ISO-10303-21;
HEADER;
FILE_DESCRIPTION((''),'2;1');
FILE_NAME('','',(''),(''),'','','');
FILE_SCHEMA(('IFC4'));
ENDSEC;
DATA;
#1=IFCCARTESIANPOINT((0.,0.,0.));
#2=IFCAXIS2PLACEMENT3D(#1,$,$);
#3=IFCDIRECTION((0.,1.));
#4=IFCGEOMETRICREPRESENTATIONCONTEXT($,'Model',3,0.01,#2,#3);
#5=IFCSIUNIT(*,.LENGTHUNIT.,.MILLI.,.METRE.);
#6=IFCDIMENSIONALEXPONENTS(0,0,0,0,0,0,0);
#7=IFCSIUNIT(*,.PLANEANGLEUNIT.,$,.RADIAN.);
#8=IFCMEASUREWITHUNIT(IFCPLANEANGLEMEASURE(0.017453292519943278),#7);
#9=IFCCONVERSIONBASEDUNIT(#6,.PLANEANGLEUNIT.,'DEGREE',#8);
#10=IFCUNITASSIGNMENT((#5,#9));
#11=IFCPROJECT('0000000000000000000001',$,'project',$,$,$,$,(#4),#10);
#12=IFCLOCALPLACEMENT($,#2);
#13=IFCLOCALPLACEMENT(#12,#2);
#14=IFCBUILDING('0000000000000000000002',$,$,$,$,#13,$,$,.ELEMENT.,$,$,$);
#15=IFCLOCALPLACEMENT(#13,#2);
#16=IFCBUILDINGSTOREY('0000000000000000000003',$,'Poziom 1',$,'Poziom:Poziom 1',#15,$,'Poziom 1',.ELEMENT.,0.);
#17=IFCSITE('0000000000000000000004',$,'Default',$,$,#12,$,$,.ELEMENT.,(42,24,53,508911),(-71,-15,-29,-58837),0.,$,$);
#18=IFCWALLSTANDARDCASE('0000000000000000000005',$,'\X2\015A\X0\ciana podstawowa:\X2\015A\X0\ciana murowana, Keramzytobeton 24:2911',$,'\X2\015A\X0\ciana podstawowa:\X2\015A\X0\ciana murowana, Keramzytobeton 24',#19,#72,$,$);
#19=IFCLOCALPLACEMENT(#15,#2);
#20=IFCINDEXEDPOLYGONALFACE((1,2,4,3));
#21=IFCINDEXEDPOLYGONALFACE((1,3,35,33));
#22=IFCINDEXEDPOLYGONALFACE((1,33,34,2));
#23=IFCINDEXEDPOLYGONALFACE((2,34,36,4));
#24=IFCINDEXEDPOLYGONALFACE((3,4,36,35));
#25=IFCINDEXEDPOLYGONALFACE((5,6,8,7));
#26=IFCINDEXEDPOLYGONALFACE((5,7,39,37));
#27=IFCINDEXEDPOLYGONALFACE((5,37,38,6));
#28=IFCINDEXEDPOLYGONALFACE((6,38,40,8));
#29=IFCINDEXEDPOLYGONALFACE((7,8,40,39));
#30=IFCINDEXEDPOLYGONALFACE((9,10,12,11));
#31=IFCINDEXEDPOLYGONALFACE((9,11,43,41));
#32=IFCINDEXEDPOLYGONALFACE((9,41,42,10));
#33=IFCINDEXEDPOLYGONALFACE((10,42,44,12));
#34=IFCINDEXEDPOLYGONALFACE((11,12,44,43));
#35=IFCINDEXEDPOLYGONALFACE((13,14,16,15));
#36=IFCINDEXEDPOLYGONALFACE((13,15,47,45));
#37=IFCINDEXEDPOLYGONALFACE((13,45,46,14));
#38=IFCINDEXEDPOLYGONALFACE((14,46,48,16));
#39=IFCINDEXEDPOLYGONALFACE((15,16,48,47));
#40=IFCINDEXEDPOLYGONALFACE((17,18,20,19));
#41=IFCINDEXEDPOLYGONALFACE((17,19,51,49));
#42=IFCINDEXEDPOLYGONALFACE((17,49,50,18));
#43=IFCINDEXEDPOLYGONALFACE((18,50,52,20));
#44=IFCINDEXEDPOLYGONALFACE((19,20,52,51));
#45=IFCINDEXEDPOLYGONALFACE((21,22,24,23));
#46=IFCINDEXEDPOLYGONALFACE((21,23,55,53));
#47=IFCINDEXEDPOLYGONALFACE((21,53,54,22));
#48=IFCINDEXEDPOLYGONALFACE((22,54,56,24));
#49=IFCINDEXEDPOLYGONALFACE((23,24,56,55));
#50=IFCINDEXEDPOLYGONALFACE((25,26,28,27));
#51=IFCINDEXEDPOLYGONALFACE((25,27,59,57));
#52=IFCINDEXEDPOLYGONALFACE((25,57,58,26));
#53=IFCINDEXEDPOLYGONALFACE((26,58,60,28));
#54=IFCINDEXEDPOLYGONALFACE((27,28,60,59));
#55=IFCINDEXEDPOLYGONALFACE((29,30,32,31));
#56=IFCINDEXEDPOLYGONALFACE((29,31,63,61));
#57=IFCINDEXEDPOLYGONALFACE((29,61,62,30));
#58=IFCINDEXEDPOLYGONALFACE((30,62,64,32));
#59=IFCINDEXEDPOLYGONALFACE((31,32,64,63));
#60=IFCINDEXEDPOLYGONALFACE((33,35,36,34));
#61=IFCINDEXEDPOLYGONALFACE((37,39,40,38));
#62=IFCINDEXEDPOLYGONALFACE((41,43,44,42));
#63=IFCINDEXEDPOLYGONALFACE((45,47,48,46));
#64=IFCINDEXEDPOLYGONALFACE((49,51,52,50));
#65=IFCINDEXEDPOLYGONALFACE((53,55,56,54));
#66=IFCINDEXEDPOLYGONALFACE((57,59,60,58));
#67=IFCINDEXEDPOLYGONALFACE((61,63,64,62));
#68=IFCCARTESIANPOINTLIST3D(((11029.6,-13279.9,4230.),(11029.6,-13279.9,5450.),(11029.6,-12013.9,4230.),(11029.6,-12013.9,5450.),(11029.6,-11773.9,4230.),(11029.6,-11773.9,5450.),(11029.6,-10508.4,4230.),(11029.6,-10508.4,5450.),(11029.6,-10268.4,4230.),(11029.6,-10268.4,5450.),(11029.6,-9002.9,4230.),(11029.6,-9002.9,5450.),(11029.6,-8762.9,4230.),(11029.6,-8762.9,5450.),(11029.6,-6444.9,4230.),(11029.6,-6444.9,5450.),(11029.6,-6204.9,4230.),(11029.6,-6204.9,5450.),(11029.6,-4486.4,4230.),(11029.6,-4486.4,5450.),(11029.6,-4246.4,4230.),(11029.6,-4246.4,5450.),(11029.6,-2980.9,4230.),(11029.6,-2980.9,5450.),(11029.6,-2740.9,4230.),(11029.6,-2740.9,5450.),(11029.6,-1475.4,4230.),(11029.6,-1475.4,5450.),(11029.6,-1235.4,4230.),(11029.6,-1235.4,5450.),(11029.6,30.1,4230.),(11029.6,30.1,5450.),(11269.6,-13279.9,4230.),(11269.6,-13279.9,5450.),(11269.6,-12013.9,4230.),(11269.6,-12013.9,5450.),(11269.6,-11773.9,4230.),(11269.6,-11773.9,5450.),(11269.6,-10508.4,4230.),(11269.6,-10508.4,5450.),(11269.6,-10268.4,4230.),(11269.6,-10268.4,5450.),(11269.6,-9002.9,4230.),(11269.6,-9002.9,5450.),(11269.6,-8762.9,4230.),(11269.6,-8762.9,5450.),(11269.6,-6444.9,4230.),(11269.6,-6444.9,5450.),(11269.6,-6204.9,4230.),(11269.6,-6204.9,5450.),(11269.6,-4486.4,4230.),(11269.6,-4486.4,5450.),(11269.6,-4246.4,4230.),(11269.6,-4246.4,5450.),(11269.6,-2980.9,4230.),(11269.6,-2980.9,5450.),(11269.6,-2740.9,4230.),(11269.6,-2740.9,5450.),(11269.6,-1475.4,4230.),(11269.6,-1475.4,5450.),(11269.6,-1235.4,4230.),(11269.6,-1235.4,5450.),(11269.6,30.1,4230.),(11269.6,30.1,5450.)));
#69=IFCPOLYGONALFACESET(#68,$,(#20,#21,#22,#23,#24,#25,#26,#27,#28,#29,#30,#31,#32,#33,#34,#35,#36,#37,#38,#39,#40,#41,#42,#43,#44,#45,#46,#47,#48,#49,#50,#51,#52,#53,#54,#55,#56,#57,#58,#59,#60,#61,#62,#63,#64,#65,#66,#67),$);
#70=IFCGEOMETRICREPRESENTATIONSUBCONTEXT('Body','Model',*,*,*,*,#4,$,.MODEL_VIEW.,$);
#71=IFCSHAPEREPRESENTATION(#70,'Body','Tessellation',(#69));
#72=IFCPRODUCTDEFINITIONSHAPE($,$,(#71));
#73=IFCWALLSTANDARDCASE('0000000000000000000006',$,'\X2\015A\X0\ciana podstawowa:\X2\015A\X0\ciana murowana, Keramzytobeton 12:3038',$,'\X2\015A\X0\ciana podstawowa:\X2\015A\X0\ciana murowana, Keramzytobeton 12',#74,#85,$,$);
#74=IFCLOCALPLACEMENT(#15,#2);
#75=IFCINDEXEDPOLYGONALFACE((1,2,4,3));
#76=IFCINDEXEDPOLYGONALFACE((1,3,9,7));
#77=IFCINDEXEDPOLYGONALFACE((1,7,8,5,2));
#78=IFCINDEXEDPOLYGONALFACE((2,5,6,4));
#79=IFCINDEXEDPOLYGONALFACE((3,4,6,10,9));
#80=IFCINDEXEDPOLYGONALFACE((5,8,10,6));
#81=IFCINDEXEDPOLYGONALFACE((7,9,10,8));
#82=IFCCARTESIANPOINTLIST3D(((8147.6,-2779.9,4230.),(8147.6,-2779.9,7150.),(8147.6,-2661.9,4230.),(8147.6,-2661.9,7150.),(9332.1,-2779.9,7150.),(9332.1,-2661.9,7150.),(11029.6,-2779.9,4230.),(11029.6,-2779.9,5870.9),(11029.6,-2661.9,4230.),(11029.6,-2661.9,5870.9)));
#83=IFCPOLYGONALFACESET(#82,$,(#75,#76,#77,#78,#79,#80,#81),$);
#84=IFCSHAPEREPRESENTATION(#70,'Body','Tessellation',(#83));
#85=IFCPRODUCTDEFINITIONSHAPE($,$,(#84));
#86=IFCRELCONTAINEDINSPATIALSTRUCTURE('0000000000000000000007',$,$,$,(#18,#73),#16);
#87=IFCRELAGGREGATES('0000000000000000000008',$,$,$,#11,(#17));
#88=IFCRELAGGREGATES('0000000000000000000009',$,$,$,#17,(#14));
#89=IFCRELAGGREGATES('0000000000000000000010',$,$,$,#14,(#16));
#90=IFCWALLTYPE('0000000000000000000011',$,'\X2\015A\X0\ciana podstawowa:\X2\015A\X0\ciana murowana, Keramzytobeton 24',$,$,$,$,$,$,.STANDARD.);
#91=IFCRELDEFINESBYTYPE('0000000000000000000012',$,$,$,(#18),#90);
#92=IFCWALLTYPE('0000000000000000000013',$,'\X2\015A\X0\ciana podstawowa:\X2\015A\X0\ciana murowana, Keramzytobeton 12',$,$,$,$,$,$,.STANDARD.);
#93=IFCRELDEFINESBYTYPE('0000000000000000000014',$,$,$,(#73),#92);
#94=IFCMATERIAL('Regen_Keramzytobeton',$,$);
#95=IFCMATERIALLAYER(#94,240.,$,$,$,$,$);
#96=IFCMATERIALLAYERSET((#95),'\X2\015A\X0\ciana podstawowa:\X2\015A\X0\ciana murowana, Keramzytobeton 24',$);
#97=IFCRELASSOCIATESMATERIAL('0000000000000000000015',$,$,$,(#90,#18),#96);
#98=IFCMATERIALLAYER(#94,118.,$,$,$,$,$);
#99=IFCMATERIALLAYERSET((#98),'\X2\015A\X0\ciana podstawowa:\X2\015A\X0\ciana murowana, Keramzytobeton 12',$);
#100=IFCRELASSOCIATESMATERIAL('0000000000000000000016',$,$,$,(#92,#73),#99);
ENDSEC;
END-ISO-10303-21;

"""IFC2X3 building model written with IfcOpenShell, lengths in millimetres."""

from ifc_helpers import new_model, entity, si_unit, converted_unit, direction, frame, frame_2d, origin, place, context, subcontext, project, spatial, rectangle, extrude, clip, halfspace, material, layer, layer_set, layer_usage, type_object, element, save


model = new_model("IFC2X3")

# Units and contexts
model_context = context("Model", 3, precision=0.01, world=origin(), true_north=direction((0.0, 1.0)))
body_context = subcontext(model_context, "Body", "Model", "MODEL_VIEW")
ifc_project = project(units=[si_unit("LENGTHUNIT", "METRE", prefix="MILLI"), converted_unit("PLANEANGLEUNIT", "DEGREE", entity("IfcPlaneAngleMeasure", 0.017453292519943278), si_unit("PLANEANGLEUNIT", "RADIAN"), dimensions=[0, 0, 0, 0, 0, 0, 0])], contexts=[model_context])

# Site, building, storey
site_placement = place(None, origin())
site = spatial("IfcSite", under=ifc_project, at=site_placement, Name="Default", CompositionType="ELEMENT", RefLatitude=(42, 24, 53, 508911), RefLongitude=(-71, -15, -29, -58837), RefElevation=0.0)
building_placement = place(site_placement, origin())
building = spatial("IfcBuilding", under=site, at=building_placement, CompositionType="ELEMENT")
storey_placement = place(building_placement, origin())
storey = spatial("IfcBuildingStorey", under=building, at=storey_placement, Name="Poziom 1", ObjectType="Poziom:Poziom 1", LongName="Poziom 1", CompositionType="ELEMENT", Elevation=0.0)

# Shared definitions
ifc_material_1 = material(Name="Regen_Keramzytobeton")
ifc_layer_1 = layer(ifc_material_1, 240.0)
ifc_layer_set_1 = layer_set([ifc_layer_1], Name="Ściana podstawowa:Ściana murowana, Keramzytobeton 24")
wall_type_1 = type_object("IfcWallType", Name="Ściana podstawowa:Ściana murowana, Keramzytobeton 24", PredefinedType="STANDARD", material=ifc_layer_set_1)

# Wall, openings
ifc_layer_usage_1 = layer_usage(ifc_layer_set_1, "AXIS2", "NEGATIVE", 120.0)
wall_1_placement = place(storey_placement, frame((11149.6, 30.1, 4230.0), z_axis=(0.0, 0.0, 1.0), x_axis=(0.0, -1.0, 0.0)))
wall_1 = element("IfcWallStandardCase", 1, at=wall_1_placement, inside=storey, type_object=wall_type_1, material=ifc_layer_usage_1, Name="Ściana podstawowa:Ściana murowana, Keramzytobeton 24:2911", ObjectType="Ściana podstawowa:Ściana murowana, Keramzytobeton 24", context=body_context, shape_type="SweptSolid", body=[
    extrude(rectangle(XDim=13310.0, YDim=240.0, at=frame_2d((6655.0, 0.0), x_axis=(-1.0, 0.0))), origin(), (0.0, 0.0, 1.0), 1220.0),
])
opening_1_placement = place(storey_placement, frame((11149.6, 30.1, 4230.0), z_axis=(0.0, 0.0, 1.0), x_axis=(0.0, -1.0, 0.0)))
element("IfcOpeningElement", 2, at=opening_1_placement, cuts=wall_1, ObjectType="Opening", context=body_context, shape_type="SweptSolid", body=[
    extrude(rectangle(XDim=1220.0, YDim=240.0, at=frame_2d((0.0, 0.0), x_axis=(1.0, 0.0))), frame((12044.0, 0.0, 610.0), z_axis=(-1.0, 0.0, 0.0), x_axis=(0.0, 0.0, 1.0)), (0.0, 0.0, 1.0), 240.0),
])
opening_2_placement = place(storey_placement, frame((11149.6, 30.1, 4230.0), z_axis=(0.0, 0.0, 1.0), x_axis=(0.0, -1.0, 0.0)))
element("IfcOpeningElement", 3, at=opening_2_placement, cuts=wall_1, ObjectType="Opening", context=body_context, shape_type="SweptSolid", body=[
    extrude(rectangle(XDim=1220.0, YDim=240.0, at=frame_2d((0.0, 0.0), x_axis=(1.0, 0.0))), frame((10538.5, 0.0, 610.0), z_axis=(-1.0, 0.0, 0.0), x_axis=(0.0, 0.0, 1.0)), (0.0, 0.0, 1.0), 240.0),
])
opening_3_placement = place(storey_placement, frame((11149.6, 30.1, 4230.0), z_axis=(0.0, 0.0, 1.0), x_axis=(0.0, -1.0, 0.0)))
element("IfcOpeningElement", 4, at=opening_3_placement, cuts=wall_1, ObjectType="Opening", context=body_context, shape_type="SweptSolid", body=[
    extrude(rectangle(XDim=1220.0, YDim=240.0, at=frame_2d((0.0, 0.0), x_axis=(1.0, 0.0))), frame((9033.0, 0.0, 610.0), z_axis=(-1.0, 0.0, 0.0), x_axis=(0.0, 0.0, 1.0)), (0.0, 0.0, 1.0), 240.0),
])
opening_4_placement = place(storey_placement, frame((11149.6, 30.1, 4230.0), z_axis=(0.0, 0.0, 1.0), x_axis=(0.0, -1.0, 0.0)))
element("IfcOpeningElement", 5, at=opening_4_placement, cuts=wall_1, ObjectType="Opening", context=body_context, shape_type="SweptSolid", body=[
    extrude(rectangle(XDim=1220.0, YDim=240.0, at=frame_2d((0.0, 0.0), x_axis=(1.0, 0.0))), frame((6475.0, 0.0, 610.0), z_axis=(-1.0, 0.0, 0.0), x_axis=(0.0, 0.0, 1.0)), (0.0, 0.0, 1.0), 240.0),
])
opening_5_placement = place(storey_placement, frame((11149.6, 30.1, 4230.0), z_axis=(0.0, 0.0, 1.0), x_axis=(0.0, -1.0, 0.0)))
element("IfcOpeningElement", 6, at=opening_5_placement, cuts=wall_1, ObjectType="Opening", context=body_context, shape_type="SweptSolid", body=[
    extrude(rectangle(XDim=1220.0, YDim=240.0, at=frame_2d((0.0, 0.0), x_axis=(1.0, 0.0))), frame((4516.5, 0.0, 610.0), z_axis=(-1.0, 0.0, 0.0), x_axis=(0.0, 0.0, 1.0)), (0.0, 0.0, 1.0), 240.0),
])
opening_6_placement = place(storey_placement, frame((11149.6, 30.1, 4230.0), z_axis=(0.0, 0.0, 1.0), x_axis=(0.0, -1.0, 0.0)))
element("IfcOpeningElement", 7, at=opening_6_placement, cuts=wall_1, ObjectType="Opening", context=body_context, shape_type="SweptSolid", body=[
    extrude(rectangle(XDim=1220.0, YDim=240.0, at=frame_2d((0.0, 0.0), x_axis=(1.0, 0.0))), frame((3011.0, 0.0, 610.0), z_axis=(-1.0, 0.0, 0.0), x_axis=(0.0, 0.0, 1.0)), (0.0, 0.0, 1.0), 240.0),
])
opening_7_placement = place(storey_placement, frame((11149.6, 30.1, 4230.0), z_axis=(0.0, 0.0, 1.0), x_axis=(0.0, -1.0, 0.0)))
element("IfcOpeningElement", 8, at=opening_7_placement, cuts=wall_1, ObjectType="Opening", context=body_context, shape_type="SweptSolid", body=[
    extrude(rectangle(XDim=1220.0, YDim=240.0, at=frame_2d((0.0, 0.0), x_axis=(1.0, 0.0))), frame((1505.5, 0.0, 610.0), z_axis=(-1.0, 0.0, 0.0), x_axis=(0.0, 0.0, 1.0)), (0.0, 0.0, 1.0), 240.0),
])

# Wall
ifc_layer_2 = layer(ifc_material_1, 118.0)
ifc_layer_set_2 = layer_set([ifc_layer_2], Name="Ściana podstawowa:Ściana murowana, Keramzytobeton 12")
ifc_layer_usage_2 = layer_usage(ifc_layer_set_2, "AXIS2", "NEGATIVE", 59.0)
wall_type_2 = type_object("IfcWallType", Name="Ściana podstawowa:Ściana murowana, Keramzytobeton 12", PredefinedType="STANDARD", material=ifc_layer_set_2)
wall_2_placement = place(storey_placement, frame((8147.6, -2720.9, 4230.0)))
element("IfcWallStandardCase", 9, at=wall_2_placement, inside=storey, type_object=wall_type_2, material=ifc_layer_usage_2, Name="Ściana podstawowa:Ściana murowana, Keramzytobeton 12:3038", ObjectType="Ściana podstawowa:Ściana murowana, Keramzytobeton 12", context=body_context, shape_type="Clipping", body=[
    clip(extrude(rectangle(XDim=2882.0, YDim=118.0, at=frame_2d((1441.0, 0.0), x_axis=(-1.0, 0.0))), origin(), (0.0, 0.0, 1.0), 2920.0), halfspace(frame((1184.5, -59.0, 2920.0), z_axis=(0.601815, 0.0, 0.798636), x_axis=(0.0, 1.0, 0.0)), False)),
])

save(model, "model.ifc")
